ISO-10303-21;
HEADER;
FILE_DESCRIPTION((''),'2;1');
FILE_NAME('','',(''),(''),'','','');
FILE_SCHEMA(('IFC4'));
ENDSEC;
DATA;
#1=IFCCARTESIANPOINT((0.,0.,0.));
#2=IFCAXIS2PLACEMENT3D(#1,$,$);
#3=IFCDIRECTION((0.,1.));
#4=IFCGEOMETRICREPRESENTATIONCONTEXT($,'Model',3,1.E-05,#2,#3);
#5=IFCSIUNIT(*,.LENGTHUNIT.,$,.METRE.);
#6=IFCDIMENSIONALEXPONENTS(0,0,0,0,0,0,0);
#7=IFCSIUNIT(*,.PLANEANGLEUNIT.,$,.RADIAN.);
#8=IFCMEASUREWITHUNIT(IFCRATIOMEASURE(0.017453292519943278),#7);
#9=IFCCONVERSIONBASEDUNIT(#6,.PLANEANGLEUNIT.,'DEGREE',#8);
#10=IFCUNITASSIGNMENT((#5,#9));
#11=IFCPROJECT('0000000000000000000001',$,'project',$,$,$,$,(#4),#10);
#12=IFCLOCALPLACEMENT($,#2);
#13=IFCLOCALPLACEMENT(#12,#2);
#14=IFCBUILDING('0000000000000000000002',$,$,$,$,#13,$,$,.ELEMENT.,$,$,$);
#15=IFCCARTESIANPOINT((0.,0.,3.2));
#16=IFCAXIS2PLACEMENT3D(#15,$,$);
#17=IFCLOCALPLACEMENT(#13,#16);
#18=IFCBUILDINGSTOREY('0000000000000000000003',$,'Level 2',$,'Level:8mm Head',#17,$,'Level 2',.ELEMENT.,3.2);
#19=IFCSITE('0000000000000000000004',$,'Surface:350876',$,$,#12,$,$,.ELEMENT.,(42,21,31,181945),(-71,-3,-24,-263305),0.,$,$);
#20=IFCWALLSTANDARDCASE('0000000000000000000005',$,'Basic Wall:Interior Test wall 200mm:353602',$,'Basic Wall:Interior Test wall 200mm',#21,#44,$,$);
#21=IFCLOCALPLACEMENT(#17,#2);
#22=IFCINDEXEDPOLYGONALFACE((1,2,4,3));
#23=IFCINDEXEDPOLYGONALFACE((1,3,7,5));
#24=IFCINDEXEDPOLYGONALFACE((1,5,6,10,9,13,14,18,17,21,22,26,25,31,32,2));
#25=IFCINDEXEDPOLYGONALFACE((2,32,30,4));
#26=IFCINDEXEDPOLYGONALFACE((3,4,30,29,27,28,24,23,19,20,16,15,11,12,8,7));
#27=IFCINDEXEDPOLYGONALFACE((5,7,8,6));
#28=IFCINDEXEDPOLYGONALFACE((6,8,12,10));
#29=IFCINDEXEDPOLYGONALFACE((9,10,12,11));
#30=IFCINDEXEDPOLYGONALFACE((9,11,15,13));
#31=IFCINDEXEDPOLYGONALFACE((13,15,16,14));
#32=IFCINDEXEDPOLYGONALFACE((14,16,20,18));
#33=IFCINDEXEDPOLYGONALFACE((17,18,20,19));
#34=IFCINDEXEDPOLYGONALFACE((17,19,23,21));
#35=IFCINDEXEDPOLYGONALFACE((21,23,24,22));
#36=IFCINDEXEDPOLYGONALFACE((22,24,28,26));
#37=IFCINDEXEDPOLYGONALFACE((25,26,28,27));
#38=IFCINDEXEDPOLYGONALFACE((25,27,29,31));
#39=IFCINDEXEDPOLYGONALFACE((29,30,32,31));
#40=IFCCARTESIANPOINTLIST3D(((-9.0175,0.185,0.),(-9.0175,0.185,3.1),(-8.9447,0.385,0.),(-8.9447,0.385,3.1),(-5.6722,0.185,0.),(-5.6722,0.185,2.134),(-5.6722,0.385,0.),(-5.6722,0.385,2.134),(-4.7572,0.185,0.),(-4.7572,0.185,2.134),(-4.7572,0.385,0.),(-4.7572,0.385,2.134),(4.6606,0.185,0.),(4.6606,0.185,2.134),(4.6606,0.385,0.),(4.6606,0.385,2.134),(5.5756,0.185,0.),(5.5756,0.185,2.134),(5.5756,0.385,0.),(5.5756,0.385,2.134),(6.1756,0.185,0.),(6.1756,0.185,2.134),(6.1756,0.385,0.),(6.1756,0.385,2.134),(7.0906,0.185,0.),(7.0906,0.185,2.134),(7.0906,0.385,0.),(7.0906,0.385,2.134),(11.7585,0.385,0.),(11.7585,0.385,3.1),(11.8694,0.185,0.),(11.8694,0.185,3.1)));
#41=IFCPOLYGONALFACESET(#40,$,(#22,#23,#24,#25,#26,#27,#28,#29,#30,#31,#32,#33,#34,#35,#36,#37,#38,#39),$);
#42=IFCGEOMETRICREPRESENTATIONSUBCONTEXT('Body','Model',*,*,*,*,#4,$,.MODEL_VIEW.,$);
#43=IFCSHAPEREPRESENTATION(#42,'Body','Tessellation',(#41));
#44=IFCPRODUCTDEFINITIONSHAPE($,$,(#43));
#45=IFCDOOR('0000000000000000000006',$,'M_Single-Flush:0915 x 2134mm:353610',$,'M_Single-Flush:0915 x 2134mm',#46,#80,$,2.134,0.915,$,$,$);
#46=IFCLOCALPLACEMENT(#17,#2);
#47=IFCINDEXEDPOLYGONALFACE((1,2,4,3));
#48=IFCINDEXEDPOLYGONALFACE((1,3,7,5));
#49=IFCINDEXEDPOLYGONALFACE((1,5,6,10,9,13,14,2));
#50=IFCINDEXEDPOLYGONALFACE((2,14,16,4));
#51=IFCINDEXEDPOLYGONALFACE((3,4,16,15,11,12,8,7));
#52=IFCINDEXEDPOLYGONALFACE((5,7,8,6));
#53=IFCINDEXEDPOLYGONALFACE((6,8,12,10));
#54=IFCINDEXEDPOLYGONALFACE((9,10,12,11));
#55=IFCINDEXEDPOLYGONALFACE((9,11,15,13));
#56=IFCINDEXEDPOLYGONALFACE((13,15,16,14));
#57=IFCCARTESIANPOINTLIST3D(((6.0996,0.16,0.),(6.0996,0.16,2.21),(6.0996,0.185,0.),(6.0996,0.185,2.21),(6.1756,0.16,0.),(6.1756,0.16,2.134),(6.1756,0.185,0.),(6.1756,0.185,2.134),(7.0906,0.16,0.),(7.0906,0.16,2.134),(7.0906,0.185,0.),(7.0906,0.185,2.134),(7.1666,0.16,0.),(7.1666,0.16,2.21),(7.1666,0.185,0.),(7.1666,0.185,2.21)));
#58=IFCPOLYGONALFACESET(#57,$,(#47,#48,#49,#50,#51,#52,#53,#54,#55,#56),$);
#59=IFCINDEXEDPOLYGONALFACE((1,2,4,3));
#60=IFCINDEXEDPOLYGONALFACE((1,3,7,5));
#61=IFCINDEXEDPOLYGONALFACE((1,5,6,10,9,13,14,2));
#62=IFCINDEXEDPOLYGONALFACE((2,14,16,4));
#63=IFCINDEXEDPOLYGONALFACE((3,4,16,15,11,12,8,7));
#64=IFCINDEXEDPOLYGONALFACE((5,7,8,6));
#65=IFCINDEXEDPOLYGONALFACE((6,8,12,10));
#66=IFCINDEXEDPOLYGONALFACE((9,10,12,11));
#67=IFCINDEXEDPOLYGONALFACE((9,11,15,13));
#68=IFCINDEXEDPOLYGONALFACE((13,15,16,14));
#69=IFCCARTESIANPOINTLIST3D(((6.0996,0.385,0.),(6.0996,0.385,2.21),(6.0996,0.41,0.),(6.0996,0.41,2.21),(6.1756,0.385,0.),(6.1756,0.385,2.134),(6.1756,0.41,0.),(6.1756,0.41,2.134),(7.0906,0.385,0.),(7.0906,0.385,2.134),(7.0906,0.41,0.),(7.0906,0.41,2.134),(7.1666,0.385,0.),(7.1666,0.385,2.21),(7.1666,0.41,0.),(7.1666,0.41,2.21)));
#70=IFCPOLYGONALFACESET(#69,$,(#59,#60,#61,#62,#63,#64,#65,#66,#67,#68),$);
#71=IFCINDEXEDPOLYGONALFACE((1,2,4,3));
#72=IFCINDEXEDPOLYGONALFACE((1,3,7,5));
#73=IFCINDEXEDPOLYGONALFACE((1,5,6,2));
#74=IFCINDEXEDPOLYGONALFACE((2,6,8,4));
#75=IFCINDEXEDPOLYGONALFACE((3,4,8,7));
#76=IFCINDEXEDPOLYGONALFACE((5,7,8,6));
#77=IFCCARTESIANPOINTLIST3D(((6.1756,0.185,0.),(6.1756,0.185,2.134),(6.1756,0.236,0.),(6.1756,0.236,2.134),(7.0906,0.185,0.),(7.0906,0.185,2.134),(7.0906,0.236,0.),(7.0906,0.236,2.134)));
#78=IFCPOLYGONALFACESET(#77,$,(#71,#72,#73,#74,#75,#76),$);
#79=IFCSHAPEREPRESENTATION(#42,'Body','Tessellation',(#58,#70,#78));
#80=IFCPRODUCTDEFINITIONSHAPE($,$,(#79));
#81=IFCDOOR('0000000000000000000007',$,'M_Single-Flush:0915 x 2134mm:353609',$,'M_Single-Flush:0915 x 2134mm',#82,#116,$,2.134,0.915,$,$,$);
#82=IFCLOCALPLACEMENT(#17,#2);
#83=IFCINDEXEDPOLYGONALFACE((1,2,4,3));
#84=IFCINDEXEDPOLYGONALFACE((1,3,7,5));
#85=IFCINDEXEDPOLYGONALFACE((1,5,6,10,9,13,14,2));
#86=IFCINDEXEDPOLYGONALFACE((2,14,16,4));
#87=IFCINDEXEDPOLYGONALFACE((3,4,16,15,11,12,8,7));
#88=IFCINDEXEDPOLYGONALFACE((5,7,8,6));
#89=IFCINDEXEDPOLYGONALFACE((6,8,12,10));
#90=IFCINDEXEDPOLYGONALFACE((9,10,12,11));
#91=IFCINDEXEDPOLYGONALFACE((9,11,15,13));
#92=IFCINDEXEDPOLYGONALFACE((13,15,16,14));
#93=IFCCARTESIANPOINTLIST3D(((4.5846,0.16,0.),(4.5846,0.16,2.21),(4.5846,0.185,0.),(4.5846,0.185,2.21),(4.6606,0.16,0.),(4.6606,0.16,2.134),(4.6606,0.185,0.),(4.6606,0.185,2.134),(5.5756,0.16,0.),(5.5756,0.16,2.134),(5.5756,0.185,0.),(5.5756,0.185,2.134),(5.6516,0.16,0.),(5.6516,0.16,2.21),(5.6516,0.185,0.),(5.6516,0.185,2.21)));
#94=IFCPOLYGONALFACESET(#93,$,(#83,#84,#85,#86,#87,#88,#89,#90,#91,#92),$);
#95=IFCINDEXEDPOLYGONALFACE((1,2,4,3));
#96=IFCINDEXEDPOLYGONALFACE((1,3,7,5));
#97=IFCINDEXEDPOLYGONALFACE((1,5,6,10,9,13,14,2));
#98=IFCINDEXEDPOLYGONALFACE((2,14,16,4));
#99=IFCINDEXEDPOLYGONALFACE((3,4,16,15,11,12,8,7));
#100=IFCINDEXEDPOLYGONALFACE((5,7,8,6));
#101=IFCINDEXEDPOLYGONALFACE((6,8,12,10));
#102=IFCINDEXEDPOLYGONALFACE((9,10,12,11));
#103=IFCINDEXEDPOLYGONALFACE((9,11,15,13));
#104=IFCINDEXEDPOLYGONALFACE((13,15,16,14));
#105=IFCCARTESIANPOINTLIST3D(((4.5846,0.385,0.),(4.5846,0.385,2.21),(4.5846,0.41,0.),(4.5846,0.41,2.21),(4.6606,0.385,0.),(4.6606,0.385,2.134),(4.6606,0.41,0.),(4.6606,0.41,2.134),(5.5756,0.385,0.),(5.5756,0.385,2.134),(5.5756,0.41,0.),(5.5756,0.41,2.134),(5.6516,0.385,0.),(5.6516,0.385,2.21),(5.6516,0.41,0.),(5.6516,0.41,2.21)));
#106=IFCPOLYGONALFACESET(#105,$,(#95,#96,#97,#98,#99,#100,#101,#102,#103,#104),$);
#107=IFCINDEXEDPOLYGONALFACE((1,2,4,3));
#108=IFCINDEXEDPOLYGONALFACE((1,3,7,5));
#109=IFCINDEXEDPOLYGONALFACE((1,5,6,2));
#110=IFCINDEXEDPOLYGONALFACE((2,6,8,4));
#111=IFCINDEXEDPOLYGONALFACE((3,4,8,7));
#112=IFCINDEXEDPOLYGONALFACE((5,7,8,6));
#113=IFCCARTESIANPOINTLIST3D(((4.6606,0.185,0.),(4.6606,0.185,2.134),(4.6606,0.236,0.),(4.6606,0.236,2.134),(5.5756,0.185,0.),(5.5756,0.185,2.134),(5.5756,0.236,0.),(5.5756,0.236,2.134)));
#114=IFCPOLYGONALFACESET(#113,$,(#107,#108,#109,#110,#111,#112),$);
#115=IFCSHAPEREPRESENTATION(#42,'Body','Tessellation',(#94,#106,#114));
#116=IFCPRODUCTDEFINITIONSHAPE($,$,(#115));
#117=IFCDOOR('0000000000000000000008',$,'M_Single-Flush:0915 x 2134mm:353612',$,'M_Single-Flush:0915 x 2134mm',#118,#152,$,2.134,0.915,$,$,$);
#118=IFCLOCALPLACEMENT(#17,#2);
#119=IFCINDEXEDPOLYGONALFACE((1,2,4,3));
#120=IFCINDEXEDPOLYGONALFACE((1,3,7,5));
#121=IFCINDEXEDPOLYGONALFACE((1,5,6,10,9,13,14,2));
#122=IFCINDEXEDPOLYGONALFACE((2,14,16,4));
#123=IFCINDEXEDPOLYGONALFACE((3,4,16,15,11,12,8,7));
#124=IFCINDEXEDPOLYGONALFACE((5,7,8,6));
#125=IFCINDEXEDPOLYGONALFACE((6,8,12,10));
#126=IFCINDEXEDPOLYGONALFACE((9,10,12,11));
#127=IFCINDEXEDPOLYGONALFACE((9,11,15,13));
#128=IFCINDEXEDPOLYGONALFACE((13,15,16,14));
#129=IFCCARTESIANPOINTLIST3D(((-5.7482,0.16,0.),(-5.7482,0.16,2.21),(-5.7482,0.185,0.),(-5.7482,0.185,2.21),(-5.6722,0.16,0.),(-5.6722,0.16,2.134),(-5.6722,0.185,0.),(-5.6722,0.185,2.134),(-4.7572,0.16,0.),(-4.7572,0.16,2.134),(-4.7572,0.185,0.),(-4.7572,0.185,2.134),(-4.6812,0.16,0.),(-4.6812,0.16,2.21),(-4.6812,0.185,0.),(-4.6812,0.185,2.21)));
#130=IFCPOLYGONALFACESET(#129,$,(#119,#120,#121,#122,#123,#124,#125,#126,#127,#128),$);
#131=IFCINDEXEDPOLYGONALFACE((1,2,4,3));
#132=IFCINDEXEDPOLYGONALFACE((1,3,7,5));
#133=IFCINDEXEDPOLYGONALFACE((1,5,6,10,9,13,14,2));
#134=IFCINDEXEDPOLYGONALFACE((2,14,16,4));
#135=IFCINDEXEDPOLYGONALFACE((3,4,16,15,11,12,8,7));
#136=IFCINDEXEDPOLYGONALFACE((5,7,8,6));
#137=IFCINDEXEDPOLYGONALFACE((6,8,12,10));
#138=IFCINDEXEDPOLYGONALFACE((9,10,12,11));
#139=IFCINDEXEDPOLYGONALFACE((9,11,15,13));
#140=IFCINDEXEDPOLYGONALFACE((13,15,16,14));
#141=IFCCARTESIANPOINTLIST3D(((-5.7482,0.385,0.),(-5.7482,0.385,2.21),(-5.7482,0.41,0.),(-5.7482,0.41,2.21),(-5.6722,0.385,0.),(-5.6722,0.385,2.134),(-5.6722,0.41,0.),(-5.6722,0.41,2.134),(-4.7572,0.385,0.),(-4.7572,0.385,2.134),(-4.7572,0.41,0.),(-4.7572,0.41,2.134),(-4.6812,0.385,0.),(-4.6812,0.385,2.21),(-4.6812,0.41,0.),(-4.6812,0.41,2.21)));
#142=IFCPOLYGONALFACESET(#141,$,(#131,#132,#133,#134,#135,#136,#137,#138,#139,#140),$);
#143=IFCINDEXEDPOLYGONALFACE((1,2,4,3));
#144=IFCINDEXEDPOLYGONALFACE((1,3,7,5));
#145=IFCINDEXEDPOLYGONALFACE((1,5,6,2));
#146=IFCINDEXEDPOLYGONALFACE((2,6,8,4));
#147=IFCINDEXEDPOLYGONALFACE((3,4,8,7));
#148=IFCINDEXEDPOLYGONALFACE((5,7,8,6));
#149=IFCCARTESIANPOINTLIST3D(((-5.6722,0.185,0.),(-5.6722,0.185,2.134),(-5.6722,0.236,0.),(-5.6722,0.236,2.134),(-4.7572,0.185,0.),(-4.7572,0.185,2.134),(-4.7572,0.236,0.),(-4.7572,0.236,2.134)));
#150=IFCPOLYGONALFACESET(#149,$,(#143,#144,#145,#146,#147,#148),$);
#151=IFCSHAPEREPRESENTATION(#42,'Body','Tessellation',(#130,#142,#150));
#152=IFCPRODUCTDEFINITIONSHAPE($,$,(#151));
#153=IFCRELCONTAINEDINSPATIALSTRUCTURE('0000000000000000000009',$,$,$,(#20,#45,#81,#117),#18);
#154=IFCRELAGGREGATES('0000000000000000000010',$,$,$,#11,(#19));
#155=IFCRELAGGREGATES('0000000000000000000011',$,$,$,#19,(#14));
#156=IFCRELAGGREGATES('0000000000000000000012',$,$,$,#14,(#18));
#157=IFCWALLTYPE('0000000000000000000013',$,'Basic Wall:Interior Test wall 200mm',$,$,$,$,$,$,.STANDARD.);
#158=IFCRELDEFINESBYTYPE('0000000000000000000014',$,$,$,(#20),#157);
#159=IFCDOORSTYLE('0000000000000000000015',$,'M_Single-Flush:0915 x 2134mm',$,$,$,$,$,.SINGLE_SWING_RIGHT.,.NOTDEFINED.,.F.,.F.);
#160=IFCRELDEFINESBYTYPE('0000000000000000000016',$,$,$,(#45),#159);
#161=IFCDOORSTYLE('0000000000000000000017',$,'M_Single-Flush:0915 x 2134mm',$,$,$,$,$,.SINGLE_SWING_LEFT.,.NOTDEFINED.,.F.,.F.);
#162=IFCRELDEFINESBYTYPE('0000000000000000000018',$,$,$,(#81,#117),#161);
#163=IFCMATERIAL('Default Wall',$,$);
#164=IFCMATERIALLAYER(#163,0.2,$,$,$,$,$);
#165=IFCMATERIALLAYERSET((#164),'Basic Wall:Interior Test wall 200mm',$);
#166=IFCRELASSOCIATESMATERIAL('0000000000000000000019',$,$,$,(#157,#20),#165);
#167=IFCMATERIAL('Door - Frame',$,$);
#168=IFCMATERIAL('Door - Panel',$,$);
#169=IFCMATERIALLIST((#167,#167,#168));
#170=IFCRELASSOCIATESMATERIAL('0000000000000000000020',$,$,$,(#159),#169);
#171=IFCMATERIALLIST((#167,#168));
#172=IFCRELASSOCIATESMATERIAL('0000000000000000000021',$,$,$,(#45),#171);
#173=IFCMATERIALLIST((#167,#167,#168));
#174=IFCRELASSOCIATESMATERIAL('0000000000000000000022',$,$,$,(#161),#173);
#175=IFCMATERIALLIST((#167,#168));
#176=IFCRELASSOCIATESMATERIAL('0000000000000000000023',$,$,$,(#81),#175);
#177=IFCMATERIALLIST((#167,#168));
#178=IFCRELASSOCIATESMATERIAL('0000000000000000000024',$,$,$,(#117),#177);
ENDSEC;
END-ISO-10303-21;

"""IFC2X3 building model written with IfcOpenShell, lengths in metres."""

from ifc_helpers import new_model, entity, si_unit, converted_unit, direction, frame, frame_2d, origin, place, context, subcontext, project, spatial, polyline, rectangle, outline, extrude, source, transform, mapped, material, material_list, layer, layer_set, layer_usage, type_object, type_shapes, element, fill, save


model = new_model("IFC2X3")

# Units and contexts
model_context = context("Model", 3, precision=1e-05, world=origin(), true_north=direction((0.0, 1.0)))
body_context = subcontext(model_context, "Body", "Model", "MODEL_VIEW")
ifc_project = project(units=[si_unit("LENGTHUNIT", "METRE"), converted_unit("PLANEANGLEUNIT", "DEGREE", entity("IfcRatioMeasure", 0.017453292519943278), si_unit("PLANEANGLEUNIT", "RADIAN"), dimensions=[0, 0, 0, 0, 0, 0, 0])], contexts=[model_context])

# Site, building, storey
site_placement = place(None, origin())
site = spatial("IfcSite", under=ifc_project, at=site_placement, Name="Surface:350876", CompositionType="ELEMENT", RefLatitude=(42, 21, 31, 181945), RefLongitude=(-71, -3, -24, -263305), RefElevation=0.0)
building_placement = place(site_placement, origin())
building = spatial("IfcBuilding", under=site, at=building_placement, CompositionType="ELEMENT")
storey_placement = place(building_placement, frame((0.0, 0.0, 3.2)))
storey = spatial("IfcBuildingStorey", under=building, at=storey_placement, Name="Level 2", ObjectType="Level:8mm Head", LongName="Level 2", CompositionType="ELEMENT", Elevation=3.2)

# Shared definitions
ifc_material_1 = material(Name="Default Wall")

# Shared definitions
ifc_layer_1 = layer(ifc_material_1, 0.2)
ifc_layer_set_1 = layer_set([ifc_layer_1], Name="Basic Wall:Interior Test wall 200mm")
wall_type_1 = type_object("IfcWallType", Name="Basic Wall:Interior Test wall 200mm", PredefinedType="STANDARD", material=ifc_layer_set_1)

# Wall, openings, doors
ifc_material_2 = material(Name="Door - Frame")
ifc_material_3 = material(Name="Door - Panel")
ifc_material_list_1 = material_list([ifc_material_2, ifc_material_2, ifc_material_3])
door_style_1 = type_object("IfcDoorStyle", Name="M_Single-Flush:0915 x 2134mm", ConstructionType="NOTDEFINED", OperationType="SINGLE_SWING_RIGHT", ParameterTakesPrecedence=False, Sizeable=False, material=ifc_material_list_1)
shared_shape_1 = source(origin(), body_context, "Body", "SweptSolid", [
    extrude(outline(polyline([(-0.5335, -1.124), (0.5335, -1.124), (0.5335, 1.086), (0.4575, 1.086), (0.4575, -1.048), (-0.4575, -1.048), (-0.4575, 1.086), (-0.5335, 1.086), (-0.5335, -1.124)])), frame((0.4575, 0.2, 1.086), z_axis=(0.0, 1.0, 0.0), x_axis=(1.0, 0.0, 0.0)), (0.0, 0.0, 1.0), 0.025),
    extrude(outline(polyline([(-1.124, -0.5335), (1.086, -0.5335), (1.086, -0.4575), (-1.048, -0.4575), (-1.048, 0.4575), (1.086, 0.4575), (1.086, 0.5335), (-1.124, 0.5335), (-1.124, -0.5335)])), frame((0.4575, -0.025, 1.086), z_axis=(0.0, 1.0, 0.0), x_axis=(0.0, 0.0, -1.0)), (0.0, 0.0, 1.0), 0.025),
    extrude(rectangle(XDim=0.051, YDim=0.915, at=frame_2d((0.0, 0.0), x_axis=(1.0, 0.0))), frame((0.4575, 0.1745, 0.0), z_axis=(0.0, 0.0, 1.0), x_axis=(0.0, 1.0, 0.0)), (0.0, 0.0, 1.0), 2.134),
])
type_shapes(door_style_1, [shared_shape_1])
ifc_layer_usage_1 = layer_usage(ifc_layer_set_1, "AXIS2", "NEGATIVE", 0.1)
wall_1_placement = place(storey_placement, frame((-9.0175, 0.285, 0.0)))
wall_1 = element("IfcWallStandardCase", 1, at=wall_1_placement, inside=storey, type_object=wall_type_1, material=ifc_layer_usage_1, Name="Basic Wall:Interior Test wall 200mm:353602", ObjectType="Basic Wall:Interior Test wall 200mm", context=body_context, shape_type="SweptSolid", body=[
    extrude(outline(polyline([(0.0, -0.1), (4.2603, -0.1), (4.4603, -0.1), (14.7931, -0.1), (14.9931, -0.1), (20.6582, -0.1), (20.8869, -0.1), (20.7761, 0.1), (0.0728, 0.1), (0.0, -0.1)])), origin(), (0.0, 0.0, 1.0), 3.1),
])
opening_1_placement = place(wall_1_placement, frame((14.5931, 0.1, 0.0)))
opening_1 = element("IfcOpeningElement", 2, at=opening_1_placement, cuts=wall_1, ObjectType="Opening", context=body_context, shape_type="SweptSolid", body=[
    extrude(rectangle(XDim=0.915, YDim=2.134, at=frame_2d((1.067, 0.4575), x_axis=(0.0, -1.0))), frame((0.0, 0.0, 0.0), z_axis=(0.0, -1.0, 0.0), x_axis=(0.0, 0.0, 1.0)), (0.0, 0.0, 1.0), 0.2),
])
opening_2_placement = place(wall_1_placement, frame((16.1081, 0.1, 0.0)))
opening_2 = element("IfcOpeningElement", 3, at=opening_2_placement, cuts=wall_1, ObjectType="Opening", context=body_context, shape_type="SweptSolid", body=[
    extrude(rectangle(XDim=0.915, YDim=2.134, at=frame_2d((1.067, 0.4575), x_axis=(0.0, 1.0))), frame((0.0, 0.0, 0.0), z_axis=(0.0, -1.0, 0.0), x_axis=(0.0, 0.0, 1.0)), (0.0, 0.0, 1.0), 0.2),
])
opening_3_placement = place(wall_1_placement, frame((4.2603, 0.1, 0.0)))
opening_3 = element("IfcOpeningElement", 4, at=opening_3_placement, cuts=wall_1, ObjectType="Opening", context=body_context, shape_type="SweptSolid", body=[
    extrude(rectangle(XDim=0.915, YDim=2.134, at=frame_2d((1.067, 0.4575), x_axis=(0.0, -1.0))), frame((0.0, 0.0, 0.0), z_axis=(0.0, -1.0, 0.0), x_axis=(0.0, 0.0, 1.0)), (0.0, 0.0, 1.0), 0.2),
])
ifc_material_list_2 = material_list([ifc_material_2, ifc_material_3])
door_1_placement = place(opening_2_placement, frame((0.0, 0.0, 0.0), z_axis=(0.0, 0.0, 1.0), x_axis=(-1.0, 0.0, 0.0)))
door_1 = element("IfcDoor", 5, at=door_1_placement, inside=storey, type_object=door_style_1, material=ifc_material_list_2, Name="M_Single-Flush:0915 x 2134mm:353610", ObjectType="M_Single-Flush:0915 x 2134mm", OverallHeight=2.134, OverallWidth=0.915, context=body_context, shape_type="MappedRepresentation", body=[
    mapped(shared_shape_1, transform((0.0, 0.0, 0.0), scale=1.0)),
])
fill(opening_2, door_1)
ifc_material_list_3 = material_list([ifc_material_2, ifc_material_3])
ifc_material_list_4 = material_list([ifc_material_2, ifc_material_2, ifc_material_3])
door_style_2 = type_object("IfcDoorStyle", Name="M_Single-Flush:0915 x 2134mm", ConstructionType="NOTDEFINED", OperationType="SINGLE_SWING_LEFT", ParameterTakesPrecedence=False, Sizeable=False, material=ifc_material_list_4)
shared_shape_2 = source(origin(), body_context, "Body", "SweptSolid", [
    extrude(outline(polyline([(-0.5335, -1.124), (0.5335, -1.124), (0.5335, 1.086), (0.4575, 1.086), (0.4575, -1.048), (-0.4575, -1.048), (-0.4575, 1.086), (-0.5335, 1.086), (-0.5335, -1.124)])), frame((0.4575, 0.225, 1.086), z_axis=(0.0, -1.0, 0.0), x_axis=(-1.0, 0.0, 0.0)), (0.0, 0.0, 1.0), 0.025),
    extrude(outline(polyline([(-1.124, -0.5335), (1.086, -0.5335), (1.086, -0.4575), (-1.048, -0.4575), (-1.048, 0.4575), (1.086, 0.4575), (1.086, 0.5335), (-1.124, 0.5335), (-1.124, -0.5335)])), frame((0.4575, 0.0, 1.086), z_axis=(0.0, -1.0, 0.0), x_axis=(0.0, 0.0, -1.0)), (0.0, 0.0, 1.0), 0.025),
    extrude(rectangle(XDim=0.915, YDim=0.051, at=frame_2d((0.0, 0.0), x_axis=(1.0, 0.0))), frame((0.4575, 0.1745, 0.0)), (0.0, 0.0, 1.0), 2.134),
])
type_shapes(door_style_2, [shared_shape_2])
door_2_placement = place(opening_1_placement, frame((0.0, 0.0, 0.0), z_axis=(0.0, 0.0, 1.0), x_axis=(-1.0, 0.0, 0.0)))
door_2 = element("IfcDoor", 6, at=door_2_placement, inside=storey, type_object=door_style_2, material=ifc_material_list_3, Name="M_Single-Flush:0915 x 2134mm:353609", ObjectType="M_Single-Flush:0915 x 2134mm", OverallHeight=2.134, OverallWidth=0.915, context=body_context, shape_type="MappedRepresentation", body=[
    mapped(shared_shape_2, transform((0.0, 0.0, 0.0), scale=1.0)),
])
fill(opening_1, door_2)
ifc_material_list_5 = material_list([ifc_material_2, ifc_material_3])
door_3_placement = place(opening_3_placement, frame((0.0, 0.0, 0.0), z_axis=(0.0, 0.0, 1.0), x_axis=(-1.0, 0.0, 0.0)))
door_3 = element("IfcDoor", 7, at=door_3_placement, inside=storey, type_object=door_style_2, material=ifc_material_list_5, Name="M_Single-Flush:0915 x 2134mm:353612", ObjectType="M_Single-Flush:0915 x 2134mm", OverallHeight=2.134, OverallWidth=0.915, context=body_context, shape_type="MappedRepresentation", body=[
    mapped(shared_shape_2, transform((0.0, 0.0, 0.0), scale=1.0)),
])
fill(opening_3, door_3)

save(model, "model.ifc")
